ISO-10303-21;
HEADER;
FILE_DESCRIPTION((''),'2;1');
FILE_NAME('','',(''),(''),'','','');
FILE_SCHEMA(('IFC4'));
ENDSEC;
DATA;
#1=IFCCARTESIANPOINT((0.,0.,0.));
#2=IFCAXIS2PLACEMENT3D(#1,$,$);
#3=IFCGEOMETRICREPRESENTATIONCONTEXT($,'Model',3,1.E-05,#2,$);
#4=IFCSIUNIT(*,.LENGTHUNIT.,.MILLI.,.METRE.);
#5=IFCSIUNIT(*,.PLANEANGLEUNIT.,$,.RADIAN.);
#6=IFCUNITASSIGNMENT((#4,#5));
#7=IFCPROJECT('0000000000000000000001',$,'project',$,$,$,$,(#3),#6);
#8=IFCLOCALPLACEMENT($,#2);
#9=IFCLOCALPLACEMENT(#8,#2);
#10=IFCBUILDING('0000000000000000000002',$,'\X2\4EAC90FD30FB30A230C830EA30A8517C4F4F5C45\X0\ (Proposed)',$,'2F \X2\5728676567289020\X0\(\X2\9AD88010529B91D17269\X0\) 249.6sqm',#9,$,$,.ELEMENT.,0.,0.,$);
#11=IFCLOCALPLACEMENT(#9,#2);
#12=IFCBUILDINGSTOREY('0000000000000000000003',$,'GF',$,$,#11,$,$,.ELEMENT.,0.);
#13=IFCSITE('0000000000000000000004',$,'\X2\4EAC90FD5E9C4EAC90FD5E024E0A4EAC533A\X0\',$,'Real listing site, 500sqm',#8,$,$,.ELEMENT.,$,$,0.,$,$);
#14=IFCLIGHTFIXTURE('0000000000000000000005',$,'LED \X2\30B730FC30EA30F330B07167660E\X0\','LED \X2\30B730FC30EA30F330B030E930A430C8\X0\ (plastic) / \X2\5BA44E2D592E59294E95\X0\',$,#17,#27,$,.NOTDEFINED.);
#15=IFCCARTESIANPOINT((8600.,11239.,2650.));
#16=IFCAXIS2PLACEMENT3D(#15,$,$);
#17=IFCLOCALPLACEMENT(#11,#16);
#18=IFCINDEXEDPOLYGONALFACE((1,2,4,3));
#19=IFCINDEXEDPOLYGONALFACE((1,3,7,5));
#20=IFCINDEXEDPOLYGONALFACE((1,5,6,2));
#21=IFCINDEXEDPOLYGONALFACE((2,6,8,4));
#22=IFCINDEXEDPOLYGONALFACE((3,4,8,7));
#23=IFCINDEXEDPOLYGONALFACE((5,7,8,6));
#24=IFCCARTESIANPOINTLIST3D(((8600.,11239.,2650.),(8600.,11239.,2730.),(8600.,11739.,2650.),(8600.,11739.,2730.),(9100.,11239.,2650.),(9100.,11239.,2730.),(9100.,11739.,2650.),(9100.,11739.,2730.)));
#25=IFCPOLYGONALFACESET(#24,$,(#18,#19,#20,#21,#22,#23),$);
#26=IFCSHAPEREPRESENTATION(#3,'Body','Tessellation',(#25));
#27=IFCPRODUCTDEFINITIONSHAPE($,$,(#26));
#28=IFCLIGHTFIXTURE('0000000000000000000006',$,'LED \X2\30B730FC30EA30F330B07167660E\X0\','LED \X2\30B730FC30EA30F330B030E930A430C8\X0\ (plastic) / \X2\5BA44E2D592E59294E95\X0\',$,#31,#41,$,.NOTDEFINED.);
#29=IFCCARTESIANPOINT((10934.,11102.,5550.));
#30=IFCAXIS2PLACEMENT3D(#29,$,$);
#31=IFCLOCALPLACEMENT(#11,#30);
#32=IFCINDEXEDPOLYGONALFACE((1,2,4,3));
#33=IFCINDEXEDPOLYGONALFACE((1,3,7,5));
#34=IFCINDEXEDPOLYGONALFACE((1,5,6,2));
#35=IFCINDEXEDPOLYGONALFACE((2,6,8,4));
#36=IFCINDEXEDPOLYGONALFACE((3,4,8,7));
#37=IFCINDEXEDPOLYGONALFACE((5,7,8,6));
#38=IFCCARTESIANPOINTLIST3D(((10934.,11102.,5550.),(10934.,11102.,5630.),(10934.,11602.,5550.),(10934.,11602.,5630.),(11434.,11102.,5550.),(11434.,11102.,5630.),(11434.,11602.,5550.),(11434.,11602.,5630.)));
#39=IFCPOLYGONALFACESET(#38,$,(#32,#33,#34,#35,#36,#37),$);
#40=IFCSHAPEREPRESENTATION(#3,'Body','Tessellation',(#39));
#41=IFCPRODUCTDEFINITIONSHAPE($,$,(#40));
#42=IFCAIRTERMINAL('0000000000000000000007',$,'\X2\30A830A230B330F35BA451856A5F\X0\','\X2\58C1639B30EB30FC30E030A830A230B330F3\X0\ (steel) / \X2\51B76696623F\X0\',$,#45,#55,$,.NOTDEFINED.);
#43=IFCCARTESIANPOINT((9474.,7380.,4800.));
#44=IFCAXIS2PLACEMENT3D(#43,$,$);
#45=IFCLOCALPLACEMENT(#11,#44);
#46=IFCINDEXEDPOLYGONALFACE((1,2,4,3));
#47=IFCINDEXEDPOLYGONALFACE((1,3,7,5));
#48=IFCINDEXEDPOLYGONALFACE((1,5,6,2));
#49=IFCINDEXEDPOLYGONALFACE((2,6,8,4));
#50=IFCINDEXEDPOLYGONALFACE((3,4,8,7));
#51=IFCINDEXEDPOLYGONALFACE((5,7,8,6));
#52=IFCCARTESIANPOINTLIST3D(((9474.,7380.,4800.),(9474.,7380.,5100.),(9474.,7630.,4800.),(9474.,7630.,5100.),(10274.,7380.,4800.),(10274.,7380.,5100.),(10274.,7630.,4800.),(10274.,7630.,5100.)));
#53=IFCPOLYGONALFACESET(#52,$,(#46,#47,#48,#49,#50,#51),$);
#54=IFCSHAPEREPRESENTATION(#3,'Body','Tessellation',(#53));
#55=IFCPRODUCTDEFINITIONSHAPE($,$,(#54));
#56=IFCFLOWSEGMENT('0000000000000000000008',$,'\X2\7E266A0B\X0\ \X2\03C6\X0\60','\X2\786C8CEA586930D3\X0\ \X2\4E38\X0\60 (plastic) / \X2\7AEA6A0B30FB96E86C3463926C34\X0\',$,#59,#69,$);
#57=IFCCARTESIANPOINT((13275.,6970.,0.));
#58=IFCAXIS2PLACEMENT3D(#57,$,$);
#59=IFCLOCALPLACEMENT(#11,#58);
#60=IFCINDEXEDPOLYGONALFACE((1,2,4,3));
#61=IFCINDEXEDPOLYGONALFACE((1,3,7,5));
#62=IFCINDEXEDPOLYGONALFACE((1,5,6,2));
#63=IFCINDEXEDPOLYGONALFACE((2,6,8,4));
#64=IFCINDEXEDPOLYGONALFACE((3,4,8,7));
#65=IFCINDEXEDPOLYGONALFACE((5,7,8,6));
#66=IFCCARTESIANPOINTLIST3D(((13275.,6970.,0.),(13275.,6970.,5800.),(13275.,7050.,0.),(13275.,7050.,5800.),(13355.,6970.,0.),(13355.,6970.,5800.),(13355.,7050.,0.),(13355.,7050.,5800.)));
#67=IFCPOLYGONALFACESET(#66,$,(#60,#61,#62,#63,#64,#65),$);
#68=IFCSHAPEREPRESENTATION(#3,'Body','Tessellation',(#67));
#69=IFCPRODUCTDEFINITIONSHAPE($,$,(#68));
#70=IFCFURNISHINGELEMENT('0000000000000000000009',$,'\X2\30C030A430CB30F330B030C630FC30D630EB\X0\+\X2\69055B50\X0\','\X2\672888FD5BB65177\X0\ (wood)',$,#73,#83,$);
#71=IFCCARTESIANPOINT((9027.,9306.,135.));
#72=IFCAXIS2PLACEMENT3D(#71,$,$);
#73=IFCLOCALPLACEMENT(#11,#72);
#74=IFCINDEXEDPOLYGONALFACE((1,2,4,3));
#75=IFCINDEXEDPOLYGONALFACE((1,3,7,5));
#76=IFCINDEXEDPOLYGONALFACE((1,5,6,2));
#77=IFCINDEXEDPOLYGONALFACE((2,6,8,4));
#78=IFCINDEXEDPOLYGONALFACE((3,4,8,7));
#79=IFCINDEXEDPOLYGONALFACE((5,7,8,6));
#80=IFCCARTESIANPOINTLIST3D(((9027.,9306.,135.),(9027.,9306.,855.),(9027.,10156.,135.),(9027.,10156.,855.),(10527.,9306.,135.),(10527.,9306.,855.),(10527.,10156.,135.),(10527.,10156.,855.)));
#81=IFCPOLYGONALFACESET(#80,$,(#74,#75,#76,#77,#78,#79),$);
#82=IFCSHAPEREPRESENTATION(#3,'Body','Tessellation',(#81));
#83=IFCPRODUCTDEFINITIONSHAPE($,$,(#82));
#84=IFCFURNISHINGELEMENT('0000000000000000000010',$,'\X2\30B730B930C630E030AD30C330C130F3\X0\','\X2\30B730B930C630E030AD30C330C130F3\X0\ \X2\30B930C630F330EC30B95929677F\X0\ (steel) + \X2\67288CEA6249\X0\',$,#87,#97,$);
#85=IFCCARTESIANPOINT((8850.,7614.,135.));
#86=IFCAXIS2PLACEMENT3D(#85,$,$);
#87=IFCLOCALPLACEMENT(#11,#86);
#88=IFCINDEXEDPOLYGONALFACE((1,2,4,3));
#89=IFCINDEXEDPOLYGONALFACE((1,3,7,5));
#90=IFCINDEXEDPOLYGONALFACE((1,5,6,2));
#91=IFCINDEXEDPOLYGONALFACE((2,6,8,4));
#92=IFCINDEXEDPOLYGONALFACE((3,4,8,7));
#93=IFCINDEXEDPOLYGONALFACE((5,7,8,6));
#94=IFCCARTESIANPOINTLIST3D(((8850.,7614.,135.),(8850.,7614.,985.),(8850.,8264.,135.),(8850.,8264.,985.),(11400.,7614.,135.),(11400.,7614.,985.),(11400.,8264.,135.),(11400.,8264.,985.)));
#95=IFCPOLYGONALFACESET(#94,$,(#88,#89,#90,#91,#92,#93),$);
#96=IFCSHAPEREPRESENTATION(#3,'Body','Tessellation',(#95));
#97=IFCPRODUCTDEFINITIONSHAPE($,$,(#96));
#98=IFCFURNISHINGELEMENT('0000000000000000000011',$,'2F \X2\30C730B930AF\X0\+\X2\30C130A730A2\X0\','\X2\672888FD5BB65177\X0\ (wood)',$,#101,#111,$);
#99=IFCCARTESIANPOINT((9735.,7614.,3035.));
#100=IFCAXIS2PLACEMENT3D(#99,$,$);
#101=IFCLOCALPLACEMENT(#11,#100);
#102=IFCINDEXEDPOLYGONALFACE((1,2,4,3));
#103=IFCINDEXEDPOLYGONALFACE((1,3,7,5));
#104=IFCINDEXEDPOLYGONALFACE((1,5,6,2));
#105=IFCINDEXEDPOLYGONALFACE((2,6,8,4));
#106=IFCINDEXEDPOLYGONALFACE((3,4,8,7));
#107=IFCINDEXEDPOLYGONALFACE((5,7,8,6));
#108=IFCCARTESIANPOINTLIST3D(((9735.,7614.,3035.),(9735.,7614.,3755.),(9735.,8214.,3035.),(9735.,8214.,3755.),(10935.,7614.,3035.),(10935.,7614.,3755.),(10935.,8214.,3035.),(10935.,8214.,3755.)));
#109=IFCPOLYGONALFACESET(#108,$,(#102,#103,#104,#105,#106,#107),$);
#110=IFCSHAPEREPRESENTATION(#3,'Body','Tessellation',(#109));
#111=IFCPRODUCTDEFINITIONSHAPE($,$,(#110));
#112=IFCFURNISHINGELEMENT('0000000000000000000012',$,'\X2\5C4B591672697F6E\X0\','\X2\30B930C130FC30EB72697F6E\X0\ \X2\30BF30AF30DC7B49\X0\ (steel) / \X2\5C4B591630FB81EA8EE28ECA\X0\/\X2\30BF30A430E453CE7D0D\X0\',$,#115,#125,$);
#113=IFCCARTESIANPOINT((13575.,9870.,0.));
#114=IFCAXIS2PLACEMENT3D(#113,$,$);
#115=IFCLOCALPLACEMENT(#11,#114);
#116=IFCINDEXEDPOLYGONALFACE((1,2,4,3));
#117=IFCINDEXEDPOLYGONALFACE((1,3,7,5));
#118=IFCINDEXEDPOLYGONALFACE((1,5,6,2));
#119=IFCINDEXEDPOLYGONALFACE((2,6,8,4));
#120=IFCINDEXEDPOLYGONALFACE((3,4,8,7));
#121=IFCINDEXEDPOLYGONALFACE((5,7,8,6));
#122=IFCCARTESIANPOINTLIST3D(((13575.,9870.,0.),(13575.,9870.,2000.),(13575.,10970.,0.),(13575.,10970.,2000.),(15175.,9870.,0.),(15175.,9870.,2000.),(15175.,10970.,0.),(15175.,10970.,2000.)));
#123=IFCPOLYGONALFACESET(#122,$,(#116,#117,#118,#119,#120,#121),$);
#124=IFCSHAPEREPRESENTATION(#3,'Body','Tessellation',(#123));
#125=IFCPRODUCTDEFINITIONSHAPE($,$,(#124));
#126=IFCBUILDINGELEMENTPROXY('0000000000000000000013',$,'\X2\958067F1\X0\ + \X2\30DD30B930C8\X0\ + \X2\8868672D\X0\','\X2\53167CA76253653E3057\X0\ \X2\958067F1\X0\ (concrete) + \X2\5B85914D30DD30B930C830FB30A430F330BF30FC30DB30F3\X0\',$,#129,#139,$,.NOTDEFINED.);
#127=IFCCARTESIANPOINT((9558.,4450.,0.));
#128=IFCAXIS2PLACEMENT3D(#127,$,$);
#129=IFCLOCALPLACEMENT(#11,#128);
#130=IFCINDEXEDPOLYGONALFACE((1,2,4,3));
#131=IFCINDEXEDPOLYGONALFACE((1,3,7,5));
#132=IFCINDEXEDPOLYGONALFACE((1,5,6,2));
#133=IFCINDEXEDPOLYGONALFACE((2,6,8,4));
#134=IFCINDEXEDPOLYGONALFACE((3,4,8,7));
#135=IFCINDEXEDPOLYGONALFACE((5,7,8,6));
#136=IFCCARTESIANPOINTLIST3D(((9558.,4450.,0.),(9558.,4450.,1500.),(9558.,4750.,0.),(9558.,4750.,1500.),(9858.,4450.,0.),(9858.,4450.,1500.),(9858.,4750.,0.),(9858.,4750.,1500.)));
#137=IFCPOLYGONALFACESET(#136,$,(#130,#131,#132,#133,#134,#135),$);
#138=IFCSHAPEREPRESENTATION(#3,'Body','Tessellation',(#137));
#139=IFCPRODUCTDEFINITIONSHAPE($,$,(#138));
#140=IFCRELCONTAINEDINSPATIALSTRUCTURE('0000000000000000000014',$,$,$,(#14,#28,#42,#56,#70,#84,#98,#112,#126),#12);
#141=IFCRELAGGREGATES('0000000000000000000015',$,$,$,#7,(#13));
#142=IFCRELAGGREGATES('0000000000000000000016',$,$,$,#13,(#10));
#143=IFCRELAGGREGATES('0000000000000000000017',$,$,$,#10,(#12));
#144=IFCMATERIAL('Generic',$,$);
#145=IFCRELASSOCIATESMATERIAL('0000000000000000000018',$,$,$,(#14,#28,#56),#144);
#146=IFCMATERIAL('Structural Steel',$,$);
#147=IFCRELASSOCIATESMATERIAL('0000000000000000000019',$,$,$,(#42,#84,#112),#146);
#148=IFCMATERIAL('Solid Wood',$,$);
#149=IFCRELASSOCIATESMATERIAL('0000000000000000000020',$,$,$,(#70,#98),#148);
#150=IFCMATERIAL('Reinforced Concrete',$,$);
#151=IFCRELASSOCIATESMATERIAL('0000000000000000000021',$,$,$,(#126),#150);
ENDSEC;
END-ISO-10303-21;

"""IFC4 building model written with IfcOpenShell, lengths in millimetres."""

from ifc_helpers import new_model, si_unit, frame, frame_2d, origin, place, context, project, spatial, rectangle, extrude, material, element, save


model = new_model("IFC4")

# Units and contexts
model_context = context("Model", 3, precision=1e-05, world=origin())
ifc_project = project(units=[si_unit("LENGTHUNIT", "METRE", prefix="MILLI"), si_unit("PLANEANGLEUNIT", "RADIAN")], contexts=[model_context])

# Site, building, storey
site_placement = place(None, origin())
site = spatial("IfcSite", under=ifc_project, at=site_placement, Name="京都府京都市上京区", ObjectType="Real listing site, 500sqm", CompositionType="ELEMENT", RefElevation=0.0)
building_placement = place(site_placement, origin())
building = spatial("IfcBuilding", under=site, at=building_placement, Name="京都・アトリエ兼住居 (Proposed)", ObjectType="2F 在来木造(高耐力金物) 249.6sqm", CompositionType="ELEMENT", ElevationOfRefHeight=0.0, ElevationOfTerrain=0.0)
storey_placement = place(building_placement, origin())
storey = spatial("IfcBuildingStorey", under=building, at=storey_placement, Name="GF", CompositionType="ELEMENT", Elevation=0.0)

# Shared definitions
ifc_material_1 = material(Name="Solid Wood")

# Shared definitions
ifc_material_2 = material(Name="Reinforced Concrete")

# Shared definitions
ifc_material_3 = material(Name="Structural Steel")

# Shared definitions
ifc_material_4 = material(Name="Generic")

# Light fixtures
light_fixture_1_placement = place(storey_placement, frame((8600.0, 11239.0, 2650.0)))
element("IfcLightFixture", 1, at=light_fixture_1_placement, inside=storey, material=ifc_material_4, Name="LED シーリング照明", Description="LED シーリングライト (plastic) / 室中央天井", PredefinedType="NOTDEFINED", context=model_context, shape_type="SweptSolid", body=[
    extrude(rectangle(XDim=500.0, YDim=500.0, at=frame_2d((250.0, 250.0))), frame((8600.0, 11239.0, 2650.0)), (0.0, 0.0, 1.0), 80.0),
])
light_fixture_2_placement = place(storey_placement, frame((10934.0, 11102.0, 5550.0)))
element("IfcLightFixture", 2, at=light_fixture_2_placement, inside=storey, material=ifc_material_4, Name="LED シーリング照明", Description="LED シーリングライト (plastic) / 室中央天井", PredefinedType="NOTDEFINED", context=model_context, shape_type="SweptSolid", body=[
    extrude(rectangle(XDim=500.0, YDim=500.0, at=frame_2d((250.0, 250.0))), frame((10934.0, 11102.0, 5550.0)), (0.0, 0.0, 1.0), 80.0),
])

# Air terminal
air_terminal_placement = place(storey_placement, frame((9474.0, 7380.0, 4800.0)))
element("IfcAirTerminal", 3, at=air_terminal_placement, inside=storey, material=ifc_material_3, Name="エアコン室内機", Description="壁掛ルームエアコン (steel) / 冷暖房", PredefinedType="NOTDEFINED", context=model_context, shape_type="SweptSolid", body=[
    extrude(rectangle(XDim=800.0, YDim=250.0, at=frame_2d((400.0, 125.0))), frame((9474.0, 7380.0, 4800.0)), (0.0, 0.0, 1.0), 300.0),
])

# Flow segment
flow_segment_placement = place(storey_placement, frame((13275.0, 6970.0, 0.0)))
element("IfcFlowSegment", 4, at=flow_segment_placement, inside=storey, material=ifc_material_4, Name="縦樋 φ60", Description="硬質塩ビ 丸60 (plastic) / 竪樋・雨水排水", context=model_context, shape_type="SweptSolid", body=[
    extrude(rectangle(XDim=80.0, YDim=80.0, at=frame_2d((40.0, 40.0))), frame((13275.0, 6970.0, 0.0)), (0.0, 0.0, 1.0), 5800.0),
])

# Furnishing elements
furnishing_1_placement = place(storey_placement, frame((9027.0, 9306.0, 135.0)))
element("IfcFurnishingElement", 5, at=furnishing_1_placement, inside=storey, material=ifc_material_1, Name="ダイニングテーブル+椅子", Description="木製家具 (wood)", context=model_context, shape_type="SweptSolid", body=[
    extrude(rectangle(XDim=1500.0, YDim=850.0, at=frame_2d((750.0, 425.0))), frame((9027.0, 9306.0, 135.0)), (0.0, 0.0, 1.0), 720.0),
])
furnishing_2_placement = place(storey_placement, frame((8850.0, 7614.0, 135.0)))
element("IfcFurnishingElement", 6, at=furnishing_2_placement, inside=storey, material=ifc_material_3, Name="システムキッチン", Description="システムキッチン ステンレス天板 (steel) + 木質扉", context=model_context, shape_type="SweptSolid", body=[
    extrude(rectangle(XDim=2550.0, YDim=650.0, at=frame_2d((1275.0, 325.0))), frame((8850.0, 7614.0, 135.0)), (0.0, 0.0, 1.0), 850.0),
])
furnishing_3_placement = place(storey_placement, frame((9735.0, 7614.0, 3035.0)))
element("IfcFurnishingElement", 7, at=furnishing_3_placement, inside=storey, material=ifc_material_1, Name="2F デスク+チェア", Description="木製家具 (wood)", context=model_context, shape_type="SweptSolid", body=[
    extrude(rectangle(XDim=1200.0, YDim=600.0, at=frame_2d((600.0, 300.0))), frame((9735.0, 7614.0, 3035.0)), (0.0, 0.0, 1.0), 720.0),
])
furnishing_4_placement = place(storey_placement, frame((13575.0, 9870.0, 0.0)))
element("IfcFurnishingElement", 8, at=furnishing_4_placement, inside=storey, material=ifc_material_3, Name="屋外物置", Description="スチール物置 タクボ等 (steel) / 屋外・自転車/タイヤ収納", context=model_context, shape_type="SweptSolid", body=[
    extrude(rectangle(XDim=1600.0, YDim=1100.0, at=frame_2d((800.0, 550.0))), frame((13575.0, 9870.0, 0.0)), (0.0, 0.0, 1.0), 2000.0),
])

# Building element proxy
proxy_placement = place(storey_placement, frame((9558.0, 4450.0, 0.0)))
element("IfcBuildingElementProxy", 9, at=proxy_placement, inside=storey, material=ifc_material_2, Name="門柱 + ポスト + 表札", Description="化粧打放し 門柱 (concrete) + 宅配ポスト・インターホン", PredefinedType="NOTDEFINED", context=model_context, shape_type="SweptSolid", body=[
    extrude(rectangle(XDim=300.0, YDim=300.0, at=frame_2d((150.0, 150.0))), frame((9558.0, 4450.0, 0.0)), (0.0, 0.0, 1.0), 1500.0),
])

save(model, "model.ifc")
